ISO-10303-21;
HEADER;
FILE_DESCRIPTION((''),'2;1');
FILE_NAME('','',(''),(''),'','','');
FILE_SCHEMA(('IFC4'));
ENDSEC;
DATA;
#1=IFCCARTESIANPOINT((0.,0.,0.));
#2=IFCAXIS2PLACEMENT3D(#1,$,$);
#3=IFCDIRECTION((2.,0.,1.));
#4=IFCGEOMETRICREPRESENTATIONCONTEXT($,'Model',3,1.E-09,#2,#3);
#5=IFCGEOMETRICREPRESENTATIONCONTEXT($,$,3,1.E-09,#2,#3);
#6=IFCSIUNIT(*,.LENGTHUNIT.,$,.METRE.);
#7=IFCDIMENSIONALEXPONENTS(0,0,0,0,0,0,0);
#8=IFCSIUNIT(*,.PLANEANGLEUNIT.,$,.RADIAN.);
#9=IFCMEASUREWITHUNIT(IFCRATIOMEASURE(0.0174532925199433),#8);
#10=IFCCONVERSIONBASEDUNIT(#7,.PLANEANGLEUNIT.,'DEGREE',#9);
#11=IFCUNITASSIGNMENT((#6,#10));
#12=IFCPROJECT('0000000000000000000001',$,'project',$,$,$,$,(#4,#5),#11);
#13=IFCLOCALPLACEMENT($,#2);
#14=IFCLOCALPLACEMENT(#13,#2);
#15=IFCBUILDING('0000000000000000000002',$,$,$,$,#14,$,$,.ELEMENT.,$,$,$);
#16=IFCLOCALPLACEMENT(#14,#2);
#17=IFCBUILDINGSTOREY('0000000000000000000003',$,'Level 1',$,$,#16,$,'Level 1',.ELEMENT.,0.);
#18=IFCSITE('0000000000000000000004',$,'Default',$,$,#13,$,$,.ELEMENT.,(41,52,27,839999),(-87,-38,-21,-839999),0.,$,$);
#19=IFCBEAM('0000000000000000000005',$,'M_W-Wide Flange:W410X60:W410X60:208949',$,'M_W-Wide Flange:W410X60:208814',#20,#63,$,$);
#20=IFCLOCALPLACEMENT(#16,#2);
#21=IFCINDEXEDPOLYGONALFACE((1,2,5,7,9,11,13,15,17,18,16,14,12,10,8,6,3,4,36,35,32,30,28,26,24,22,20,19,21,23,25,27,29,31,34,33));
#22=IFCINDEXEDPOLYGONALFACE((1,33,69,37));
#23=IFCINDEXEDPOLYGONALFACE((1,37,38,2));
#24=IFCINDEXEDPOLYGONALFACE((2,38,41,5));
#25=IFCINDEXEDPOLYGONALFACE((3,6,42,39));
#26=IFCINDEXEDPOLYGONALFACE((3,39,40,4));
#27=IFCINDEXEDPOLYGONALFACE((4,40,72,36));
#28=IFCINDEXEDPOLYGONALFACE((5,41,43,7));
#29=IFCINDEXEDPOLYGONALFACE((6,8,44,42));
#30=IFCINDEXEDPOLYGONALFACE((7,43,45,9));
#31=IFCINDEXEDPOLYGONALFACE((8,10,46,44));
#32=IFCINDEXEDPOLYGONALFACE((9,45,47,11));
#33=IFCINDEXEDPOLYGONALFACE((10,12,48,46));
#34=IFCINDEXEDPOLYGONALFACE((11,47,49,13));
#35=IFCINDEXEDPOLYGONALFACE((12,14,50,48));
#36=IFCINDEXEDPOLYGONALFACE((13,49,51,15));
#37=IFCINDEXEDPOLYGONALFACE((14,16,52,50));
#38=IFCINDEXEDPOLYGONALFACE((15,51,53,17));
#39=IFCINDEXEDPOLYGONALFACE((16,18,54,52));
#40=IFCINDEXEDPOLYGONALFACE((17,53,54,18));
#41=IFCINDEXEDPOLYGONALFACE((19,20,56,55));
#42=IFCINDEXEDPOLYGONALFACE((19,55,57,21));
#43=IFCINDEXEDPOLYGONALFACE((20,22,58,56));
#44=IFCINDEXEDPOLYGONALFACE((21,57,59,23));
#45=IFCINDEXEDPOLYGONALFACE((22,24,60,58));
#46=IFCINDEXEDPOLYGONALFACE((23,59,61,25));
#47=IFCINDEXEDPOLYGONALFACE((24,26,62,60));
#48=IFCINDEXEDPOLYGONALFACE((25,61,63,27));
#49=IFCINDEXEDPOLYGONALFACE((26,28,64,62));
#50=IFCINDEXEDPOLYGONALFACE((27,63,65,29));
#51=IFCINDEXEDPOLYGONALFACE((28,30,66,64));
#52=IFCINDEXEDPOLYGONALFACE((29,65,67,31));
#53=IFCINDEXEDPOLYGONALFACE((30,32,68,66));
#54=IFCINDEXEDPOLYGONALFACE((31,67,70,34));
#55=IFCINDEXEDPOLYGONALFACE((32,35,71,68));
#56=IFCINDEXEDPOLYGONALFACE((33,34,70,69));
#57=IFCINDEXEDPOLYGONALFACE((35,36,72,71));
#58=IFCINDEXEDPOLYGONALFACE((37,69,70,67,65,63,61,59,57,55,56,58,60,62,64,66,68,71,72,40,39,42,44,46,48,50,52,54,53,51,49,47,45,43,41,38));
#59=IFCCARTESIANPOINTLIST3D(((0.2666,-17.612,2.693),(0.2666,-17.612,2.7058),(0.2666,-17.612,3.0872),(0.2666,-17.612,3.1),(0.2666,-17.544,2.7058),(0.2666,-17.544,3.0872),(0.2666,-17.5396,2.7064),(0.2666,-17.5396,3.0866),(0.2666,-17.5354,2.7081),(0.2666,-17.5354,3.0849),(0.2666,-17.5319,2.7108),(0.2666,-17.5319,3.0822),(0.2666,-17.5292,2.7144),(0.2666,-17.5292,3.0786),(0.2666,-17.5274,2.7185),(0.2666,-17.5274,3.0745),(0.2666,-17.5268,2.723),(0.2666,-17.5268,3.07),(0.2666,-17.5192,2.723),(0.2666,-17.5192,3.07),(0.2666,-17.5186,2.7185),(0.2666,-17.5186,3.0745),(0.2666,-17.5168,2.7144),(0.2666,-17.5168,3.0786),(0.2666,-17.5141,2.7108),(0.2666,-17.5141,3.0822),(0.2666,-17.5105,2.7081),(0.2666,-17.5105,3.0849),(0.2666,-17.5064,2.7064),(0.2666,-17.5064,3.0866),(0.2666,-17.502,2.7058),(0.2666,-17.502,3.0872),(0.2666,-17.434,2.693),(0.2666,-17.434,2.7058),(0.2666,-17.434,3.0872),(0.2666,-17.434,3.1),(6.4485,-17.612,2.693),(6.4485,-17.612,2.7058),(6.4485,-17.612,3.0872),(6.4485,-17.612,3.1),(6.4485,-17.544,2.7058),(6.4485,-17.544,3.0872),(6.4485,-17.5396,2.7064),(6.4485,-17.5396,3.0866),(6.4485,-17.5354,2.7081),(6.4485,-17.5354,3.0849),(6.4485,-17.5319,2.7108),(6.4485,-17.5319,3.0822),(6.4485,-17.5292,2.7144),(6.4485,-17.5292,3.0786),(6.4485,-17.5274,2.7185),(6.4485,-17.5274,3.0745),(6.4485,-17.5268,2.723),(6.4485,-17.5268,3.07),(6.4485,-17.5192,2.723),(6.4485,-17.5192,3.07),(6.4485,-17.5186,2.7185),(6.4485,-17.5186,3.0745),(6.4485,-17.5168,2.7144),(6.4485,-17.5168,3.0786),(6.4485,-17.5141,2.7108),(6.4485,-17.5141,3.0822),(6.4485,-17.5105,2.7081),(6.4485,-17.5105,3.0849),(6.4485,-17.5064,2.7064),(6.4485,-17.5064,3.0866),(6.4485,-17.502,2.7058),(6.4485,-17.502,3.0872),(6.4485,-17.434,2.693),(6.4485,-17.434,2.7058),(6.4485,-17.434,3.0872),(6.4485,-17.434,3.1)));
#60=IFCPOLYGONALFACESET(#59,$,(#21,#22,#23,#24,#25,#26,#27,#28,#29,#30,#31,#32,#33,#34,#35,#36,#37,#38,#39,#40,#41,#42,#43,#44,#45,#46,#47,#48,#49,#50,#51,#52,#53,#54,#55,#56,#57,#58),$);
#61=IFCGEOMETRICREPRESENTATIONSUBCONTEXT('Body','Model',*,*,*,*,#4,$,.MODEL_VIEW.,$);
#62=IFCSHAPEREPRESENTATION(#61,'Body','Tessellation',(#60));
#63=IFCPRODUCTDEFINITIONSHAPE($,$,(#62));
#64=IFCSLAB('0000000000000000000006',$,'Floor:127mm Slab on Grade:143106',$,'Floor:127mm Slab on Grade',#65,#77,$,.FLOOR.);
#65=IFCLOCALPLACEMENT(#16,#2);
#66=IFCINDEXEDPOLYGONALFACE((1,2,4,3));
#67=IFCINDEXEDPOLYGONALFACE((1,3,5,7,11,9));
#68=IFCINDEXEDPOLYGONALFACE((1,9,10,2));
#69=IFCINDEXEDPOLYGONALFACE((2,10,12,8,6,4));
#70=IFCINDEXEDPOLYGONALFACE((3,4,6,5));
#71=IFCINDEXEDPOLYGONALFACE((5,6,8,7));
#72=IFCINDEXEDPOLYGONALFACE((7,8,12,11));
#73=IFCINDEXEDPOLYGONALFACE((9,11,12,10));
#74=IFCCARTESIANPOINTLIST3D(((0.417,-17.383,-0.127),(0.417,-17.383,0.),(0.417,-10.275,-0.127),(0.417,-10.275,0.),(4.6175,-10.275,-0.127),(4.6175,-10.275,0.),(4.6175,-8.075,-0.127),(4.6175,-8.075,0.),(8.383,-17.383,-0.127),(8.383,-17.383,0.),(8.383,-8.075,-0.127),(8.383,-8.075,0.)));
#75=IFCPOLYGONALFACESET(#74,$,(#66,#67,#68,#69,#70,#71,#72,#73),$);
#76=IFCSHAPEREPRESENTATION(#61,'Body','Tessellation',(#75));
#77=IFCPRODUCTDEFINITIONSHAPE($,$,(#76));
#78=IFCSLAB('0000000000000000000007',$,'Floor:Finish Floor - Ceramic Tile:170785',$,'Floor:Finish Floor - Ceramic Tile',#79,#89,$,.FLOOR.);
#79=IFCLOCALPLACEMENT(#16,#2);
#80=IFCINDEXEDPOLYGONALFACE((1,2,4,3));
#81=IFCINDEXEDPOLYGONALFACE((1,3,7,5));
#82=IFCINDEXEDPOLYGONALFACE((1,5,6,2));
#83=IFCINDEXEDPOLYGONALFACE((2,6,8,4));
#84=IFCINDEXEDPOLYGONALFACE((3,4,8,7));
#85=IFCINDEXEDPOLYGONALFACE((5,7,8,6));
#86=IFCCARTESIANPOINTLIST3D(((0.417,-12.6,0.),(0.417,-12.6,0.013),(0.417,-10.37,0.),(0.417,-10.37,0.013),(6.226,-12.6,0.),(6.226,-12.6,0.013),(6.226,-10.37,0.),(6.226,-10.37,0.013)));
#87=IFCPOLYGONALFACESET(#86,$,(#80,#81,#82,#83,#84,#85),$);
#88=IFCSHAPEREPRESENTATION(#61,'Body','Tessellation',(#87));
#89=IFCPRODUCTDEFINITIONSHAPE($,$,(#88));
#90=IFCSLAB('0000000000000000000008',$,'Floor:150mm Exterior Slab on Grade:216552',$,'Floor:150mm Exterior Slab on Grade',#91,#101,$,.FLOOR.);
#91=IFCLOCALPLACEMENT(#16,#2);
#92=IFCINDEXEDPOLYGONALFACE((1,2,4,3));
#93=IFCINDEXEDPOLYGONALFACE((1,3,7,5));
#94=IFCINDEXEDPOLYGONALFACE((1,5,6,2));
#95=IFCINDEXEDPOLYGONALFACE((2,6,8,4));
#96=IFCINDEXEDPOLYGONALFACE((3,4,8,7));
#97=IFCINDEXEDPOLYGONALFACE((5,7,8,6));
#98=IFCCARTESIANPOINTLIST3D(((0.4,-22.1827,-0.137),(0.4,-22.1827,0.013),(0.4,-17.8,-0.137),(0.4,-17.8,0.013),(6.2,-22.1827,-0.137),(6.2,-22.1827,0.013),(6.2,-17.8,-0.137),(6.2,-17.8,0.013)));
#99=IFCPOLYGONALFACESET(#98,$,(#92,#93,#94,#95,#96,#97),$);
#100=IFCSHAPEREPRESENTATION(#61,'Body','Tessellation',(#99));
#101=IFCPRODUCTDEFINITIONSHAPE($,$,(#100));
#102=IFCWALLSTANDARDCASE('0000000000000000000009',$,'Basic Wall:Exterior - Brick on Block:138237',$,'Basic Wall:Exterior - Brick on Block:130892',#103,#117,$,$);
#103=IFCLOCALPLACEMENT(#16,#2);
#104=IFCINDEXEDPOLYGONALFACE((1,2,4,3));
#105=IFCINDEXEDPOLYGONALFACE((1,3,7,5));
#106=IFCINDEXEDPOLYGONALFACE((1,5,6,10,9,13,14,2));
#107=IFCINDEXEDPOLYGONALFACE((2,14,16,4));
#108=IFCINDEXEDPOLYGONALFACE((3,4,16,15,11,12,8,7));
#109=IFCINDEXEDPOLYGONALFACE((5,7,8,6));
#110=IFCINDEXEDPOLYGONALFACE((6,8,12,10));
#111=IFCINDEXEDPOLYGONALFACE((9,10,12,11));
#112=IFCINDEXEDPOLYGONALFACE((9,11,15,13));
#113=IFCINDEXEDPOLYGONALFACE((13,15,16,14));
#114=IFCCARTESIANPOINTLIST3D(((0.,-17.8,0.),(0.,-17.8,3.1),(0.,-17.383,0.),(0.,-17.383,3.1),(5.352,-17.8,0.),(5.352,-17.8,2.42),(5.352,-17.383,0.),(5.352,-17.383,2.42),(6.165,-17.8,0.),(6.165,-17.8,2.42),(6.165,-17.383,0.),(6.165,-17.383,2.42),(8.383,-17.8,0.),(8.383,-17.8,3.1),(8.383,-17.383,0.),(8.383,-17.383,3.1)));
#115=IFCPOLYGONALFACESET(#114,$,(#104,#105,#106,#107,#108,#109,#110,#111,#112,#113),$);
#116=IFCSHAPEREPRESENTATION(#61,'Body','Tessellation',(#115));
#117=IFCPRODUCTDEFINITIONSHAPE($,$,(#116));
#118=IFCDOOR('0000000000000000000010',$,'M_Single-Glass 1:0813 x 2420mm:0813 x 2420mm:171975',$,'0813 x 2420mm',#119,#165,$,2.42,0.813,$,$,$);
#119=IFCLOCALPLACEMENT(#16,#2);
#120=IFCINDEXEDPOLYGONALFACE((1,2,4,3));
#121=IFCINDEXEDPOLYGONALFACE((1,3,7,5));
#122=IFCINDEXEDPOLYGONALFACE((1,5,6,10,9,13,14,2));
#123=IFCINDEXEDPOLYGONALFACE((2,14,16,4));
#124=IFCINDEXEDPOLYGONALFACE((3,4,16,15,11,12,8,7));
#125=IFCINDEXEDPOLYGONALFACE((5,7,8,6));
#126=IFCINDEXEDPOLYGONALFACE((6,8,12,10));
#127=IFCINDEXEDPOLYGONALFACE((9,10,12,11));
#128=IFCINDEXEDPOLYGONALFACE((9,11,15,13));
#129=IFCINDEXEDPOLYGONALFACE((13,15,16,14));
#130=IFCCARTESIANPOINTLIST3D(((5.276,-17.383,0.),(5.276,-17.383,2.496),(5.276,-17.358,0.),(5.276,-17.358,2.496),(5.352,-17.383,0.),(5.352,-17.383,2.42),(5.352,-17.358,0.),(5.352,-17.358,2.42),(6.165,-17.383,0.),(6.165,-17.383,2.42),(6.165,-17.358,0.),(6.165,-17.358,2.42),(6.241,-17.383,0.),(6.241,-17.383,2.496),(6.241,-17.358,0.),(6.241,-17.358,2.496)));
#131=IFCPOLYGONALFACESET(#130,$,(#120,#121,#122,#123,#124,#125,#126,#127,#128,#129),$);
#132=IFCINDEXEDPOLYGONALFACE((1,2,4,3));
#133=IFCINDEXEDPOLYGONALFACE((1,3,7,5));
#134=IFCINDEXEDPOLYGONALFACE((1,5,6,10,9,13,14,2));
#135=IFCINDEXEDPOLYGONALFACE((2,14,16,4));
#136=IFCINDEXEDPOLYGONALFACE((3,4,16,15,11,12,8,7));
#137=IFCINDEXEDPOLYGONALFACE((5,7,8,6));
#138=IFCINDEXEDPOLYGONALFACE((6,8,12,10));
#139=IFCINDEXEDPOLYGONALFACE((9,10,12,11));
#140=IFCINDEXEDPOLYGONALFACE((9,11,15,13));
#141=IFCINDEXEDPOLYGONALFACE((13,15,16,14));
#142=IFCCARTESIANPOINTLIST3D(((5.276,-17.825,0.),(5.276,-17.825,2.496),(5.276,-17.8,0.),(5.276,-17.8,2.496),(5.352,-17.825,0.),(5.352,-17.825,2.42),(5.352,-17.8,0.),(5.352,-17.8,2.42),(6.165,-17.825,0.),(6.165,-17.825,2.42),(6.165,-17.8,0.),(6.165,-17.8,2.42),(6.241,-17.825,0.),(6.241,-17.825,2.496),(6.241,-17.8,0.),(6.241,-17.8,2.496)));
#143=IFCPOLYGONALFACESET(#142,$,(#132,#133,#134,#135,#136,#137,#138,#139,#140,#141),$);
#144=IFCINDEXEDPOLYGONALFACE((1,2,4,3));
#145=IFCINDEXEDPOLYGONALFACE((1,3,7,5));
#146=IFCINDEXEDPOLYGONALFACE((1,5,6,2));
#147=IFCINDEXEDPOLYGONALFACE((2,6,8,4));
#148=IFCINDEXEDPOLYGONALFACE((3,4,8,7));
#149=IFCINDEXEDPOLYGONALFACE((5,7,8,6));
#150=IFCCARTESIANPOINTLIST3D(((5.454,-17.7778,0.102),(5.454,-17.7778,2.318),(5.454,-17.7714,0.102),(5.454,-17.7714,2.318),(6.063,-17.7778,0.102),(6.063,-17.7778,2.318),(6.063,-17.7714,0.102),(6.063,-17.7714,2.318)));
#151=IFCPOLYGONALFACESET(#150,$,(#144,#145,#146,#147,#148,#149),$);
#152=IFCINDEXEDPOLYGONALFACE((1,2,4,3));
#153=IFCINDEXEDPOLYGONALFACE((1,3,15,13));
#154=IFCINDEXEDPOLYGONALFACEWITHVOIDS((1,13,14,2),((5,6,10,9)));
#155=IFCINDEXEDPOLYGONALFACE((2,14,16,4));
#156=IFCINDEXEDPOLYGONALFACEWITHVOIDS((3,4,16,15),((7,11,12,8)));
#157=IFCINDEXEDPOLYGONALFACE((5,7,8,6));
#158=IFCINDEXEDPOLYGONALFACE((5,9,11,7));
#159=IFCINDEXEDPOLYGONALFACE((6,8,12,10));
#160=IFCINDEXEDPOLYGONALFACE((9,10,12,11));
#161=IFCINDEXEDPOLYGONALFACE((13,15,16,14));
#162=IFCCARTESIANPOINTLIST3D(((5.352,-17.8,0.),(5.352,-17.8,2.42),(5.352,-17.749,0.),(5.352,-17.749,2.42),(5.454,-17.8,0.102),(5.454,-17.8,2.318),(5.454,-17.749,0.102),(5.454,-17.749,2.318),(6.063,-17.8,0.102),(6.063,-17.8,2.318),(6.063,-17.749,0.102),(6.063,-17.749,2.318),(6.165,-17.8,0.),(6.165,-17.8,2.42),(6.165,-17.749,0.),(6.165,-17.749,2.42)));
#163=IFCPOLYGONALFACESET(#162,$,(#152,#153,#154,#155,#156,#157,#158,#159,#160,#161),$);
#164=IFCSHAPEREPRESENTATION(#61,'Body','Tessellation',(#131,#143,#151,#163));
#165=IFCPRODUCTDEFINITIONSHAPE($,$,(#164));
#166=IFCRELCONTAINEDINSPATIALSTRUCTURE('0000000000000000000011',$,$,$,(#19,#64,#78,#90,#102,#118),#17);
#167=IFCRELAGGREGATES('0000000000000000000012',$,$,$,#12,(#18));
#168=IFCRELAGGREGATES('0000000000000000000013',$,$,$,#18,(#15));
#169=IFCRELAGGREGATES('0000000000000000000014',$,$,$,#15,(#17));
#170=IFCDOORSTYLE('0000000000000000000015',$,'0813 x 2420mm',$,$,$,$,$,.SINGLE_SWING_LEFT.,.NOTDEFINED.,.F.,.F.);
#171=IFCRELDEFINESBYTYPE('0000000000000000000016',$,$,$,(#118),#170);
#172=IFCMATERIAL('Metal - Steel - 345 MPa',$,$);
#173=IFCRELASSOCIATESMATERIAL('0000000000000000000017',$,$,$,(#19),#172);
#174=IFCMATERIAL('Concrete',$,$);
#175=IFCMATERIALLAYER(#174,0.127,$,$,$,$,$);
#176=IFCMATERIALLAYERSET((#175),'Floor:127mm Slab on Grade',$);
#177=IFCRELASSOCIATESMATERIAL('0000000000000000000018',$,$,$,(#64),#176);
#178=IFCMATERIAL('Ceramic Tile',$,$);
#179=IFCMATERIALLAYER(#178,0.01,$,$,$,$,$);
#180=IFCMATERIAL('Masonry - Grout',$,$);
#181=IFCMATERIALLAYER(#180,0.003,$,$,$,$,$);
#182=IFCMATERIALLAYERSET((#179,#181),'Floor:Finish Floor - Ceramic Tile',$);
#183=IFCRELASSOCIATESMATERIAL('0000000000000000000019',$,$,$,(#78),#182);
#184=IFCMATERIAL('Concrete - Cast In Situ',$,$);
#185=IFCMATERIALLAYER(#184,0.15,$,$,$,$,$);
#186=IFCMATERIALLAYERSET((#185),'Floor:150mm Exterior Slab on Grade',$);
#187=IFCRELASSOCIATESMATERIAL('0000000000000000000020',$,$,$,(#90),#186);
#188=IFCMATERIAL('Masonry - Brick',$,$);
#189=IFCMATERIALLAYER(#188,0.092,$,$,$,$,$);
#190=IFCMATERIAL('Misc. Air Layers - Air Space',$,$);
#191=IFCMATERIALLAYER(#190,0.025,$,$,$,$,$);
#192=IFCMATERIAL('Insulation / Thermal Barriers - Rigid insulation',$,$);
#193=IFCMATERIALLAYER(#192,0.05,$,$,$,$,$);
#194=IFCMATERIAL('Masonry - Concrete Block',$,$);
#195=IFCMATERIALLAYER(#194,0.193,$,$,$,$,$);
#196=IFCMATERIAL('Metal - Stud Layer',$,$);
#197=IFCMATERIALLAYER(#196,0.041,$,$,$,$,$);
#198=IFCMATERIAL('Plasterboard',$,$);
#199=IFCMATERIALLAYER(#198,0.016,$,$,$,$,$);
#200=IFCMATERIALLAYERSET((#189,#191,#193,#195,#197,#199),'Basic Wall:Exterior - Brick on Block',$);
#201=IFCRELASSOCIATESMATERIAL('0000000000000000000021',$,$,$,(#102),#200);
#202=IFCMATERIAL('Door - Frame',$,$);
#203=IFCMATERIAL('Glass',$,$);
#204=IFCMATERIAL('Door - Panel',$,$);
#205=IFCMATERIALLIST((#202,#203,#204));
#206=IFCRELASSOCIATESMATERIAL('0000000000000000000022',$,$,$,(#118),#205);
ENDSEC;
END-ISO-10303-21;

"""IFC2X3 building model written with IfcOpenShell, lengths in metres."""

from ifc_helpers import new_model, entity, si_unit, converted_unit, direction, frame, frame_2d, origin, origin_2d_with_axis, place, context, subcontext, project, spatial, polyline, rectangle, i_section, outline, extrude, source, transform, mapped, material, material_list, layer, layer_set, layer_usage, type_object, type_shapes, element, fill, save


model = new_model("IFC2X3")

# Units and contexts
model_context = context("Model", 3, precision=1e-09, world=origin(), true_north=direction((2.0, 0.0, 1.0)))
context_of_model = context(None, 3, precision=1e-09, world=origin(), true_north=direction((2.0, 0.0, 1.0)))
body_context = subcontext(model_context, "Body", "Model", "MODEL_VIEW")
ifc_project = project(units=[si_unit("LENGTHUNIT", "METRE"), converted_unit("PLANEANGLEUNIT", "DEGREE", entity("IfcRatioMeasure", 0.0174532925199433), si_unit("PLANEANGLEUNIT", "RADIAN"), dimensions=[0, 0, 0, 0, 0, 0, 0])], contexts=[model_context, context_of_model])

# Site, building, storey
site_placement = place(None, origin())
site = spatial("IfcSite", under=ifc_project, at=site_placement, Name="Default", CompositionType="ELEMENT", RefLatitude=(41, 52, 27, 839999), RefLongitude=(-87, -38, -21, -839999), RefElevation=0.0)
building_placement = place(site_placement, origin())
building = spatial("IfcBuilding", under=site, at=building_placement, CompositionType="ELEMENT")
storey_placement = place(building_placement, origin())
storey = spatial("IfcBuildingStorey", under=building, at=storey_placement, Name="Level 1", LongName="Level 1", CompositionType="ELEMENT", Elevation=0.0)

# Beam
ifc_material_1 = material(Name="Metal - Steel - 345 MPa")
beam_placement = place(storey_placement, frame((0.2085, -17.523, 3.1)))
element("IfcBeam", 1, at=beam_placement, inside=storey, material=ifc_material_1, Name="M_W-Wide Flange:W410X60:W410X60:208949", ObjectType="M_W-Wide Flange:W410X60:208814", context=body_context, shape_type="SweptSolid", body=[
    extrude(i_section(OverallWidth=0.178, OverallDepth=0.407, WebThickness=0.0077, FlangeThickness=0.0128, FilletRadius=0.0172, at=frame_2d((0.0, 0.0), x_axis=(1.0, 0.0))), frame((0.0581, 0.0, -0.2035), z_axis=(-1.0, 0.0, 0.0), x_axis=(0.0, -1.0, 0.0)), (0.0, 0.0, -1.0), 6.1819),
])

# Slabs
ifc_material_2 = material(Name="Concrete")
ifc_layer_1 = layer(ifc_material_2, 0.127)
ifc_layer_set_1 = layer_set([ifc_layer_1], Name="Floor:127mm Slab on Grade")
ifc_layer_usage_1 = layer_usage(ifc_layer_set_1, "AXIS3", "POSITIVE", 0.0)
slab_1_placement = place(storey_placement, frame((0.417, -17.383, -0.127)))
element("IfcSlab", 2, at=slab_1_placement, inside=storey, material=ifc_layer_usage_1, Name="Floor:127mm Slab on Grade:143106", ObjectType="Floor:127mm Slab on Grade", PredefinedType="FLOOR", context=body_context, shape_type="SweptSolid", body=[
    extrude(outline(polyline([(-3.983, 4.654), (-3.983, -4.654), (3.983, -4.654), (3.983, 2.454), (-0.2175, 2.454), (-0.2175, 4.654), (-3.983, 4.654)])), frame((3.983, 4.654, 0.127), z_axis=(0.0, 0.0, -1.0), x_axis=(-1.0, 0.0, 0.0)), (0.0, 0.0, 1.0), 0.127),
])
ifc_material_3 = material(Name="Ceramic Tile")
ifc_layer_2 = layer(ifc_material_3, 0.01)
ifc_material_4 = material(Name="Masonry - Grout")
ifc_layer_3 = layer(ifc_material_4, 0.003)
ifc_layer_set_2 = layer_set([ifc_layer_2, ifc_layer_3], Name="Floor:Finish Floor - Ceramic Tile")
ifc_layer_usage_2 = layer_usage(ifc_layer_set_2, "AXIS3", "POSITIVE", 0.0)
slab_2_placement = place(storey_placement, frame((0.417, -12.6, 0.0)))
element("IfcSlab", 3, at=slab_2_placement, inside=storey, material=ifc_layer_usage_2, Name="Floor:Finish Floor - Ceramic Tile:170785", ObjectType="Floor:Finish Floor - Ceramic Tile", PredefinedType="FLOOR", context=body_context, shape_type="SweptSolid", body=[
    extrude(rectangle(XDim=5.809, YDim=2.23, at=frame_2d((0.0, 0.0), x_axis=(-1.0, 0.0))), frame((2.9045, 1.115, 0.013), z_axis=(0.0, 0.0, -1.0), x_axis=(-1.0, 0.0, 0.0)), (0.0, 0.0, 1.0), 0.013),
])
ifc_material_5 = material(Name="Concrete - Cast In Situ")
ifc_layer_4 = layer(ifc_material_5, 0.15)
ifc_layer_set_3 = layer_set([ifc_layer_4], Name="Floor:150mm Exterior Slab on Grade")
ifc_layer_usage_3 = layer_usage(ifc_layer_set_3, "AXIS3", "POSITIVE", 0.0)
slab_3_placement = place(storey_placement, frame((0.4, -22.1827, -0.137)))
element("IfcSlab", 4, at=slab_3_placement, inside=storey, material=ifc_layer_usage_3, Name="Floor:150mm Exterior Slab on Grade:216552", ObjectType="Floor:150mm Exterior Slab on Grade", PredefinedType="FLOOR", context=body_context, shape_type="SweptSolid", body=[
    extrude(rectangle(XDim=5.8, YDim=4.3827, at=origin_2d_with_axis()), frame((2.9, 2.1914, 0.15), z_axis=(0.0, 0.0, -1.0), x_axis=(-1.0, 0.0, 0.0)), (0.0, 0.0, 1.0), 0.15),
])

# Wall, opening, door
ifc_material_6 = material(Name="Masonry - Brick")
ifc_layer_5 = layer(ifc_material_6, 0.092)
ifc_material_7 = material(Name="Misc. Air Layers - Air Space")
ifc_layer_6 = layer(ifc_material_7, 0.025)
ifc_material_8 = material(Name="Insulation / Thermal Barriers - Rigid insulation")
ifc_layer_7 = layer(ifc_material_8, 0.05)
ifc_material_9 = material(Name="Masonry - Concrete Block")
ifc_layer_8 = layer(ifc_material_9, 0.193)
ifc_material_10 = material(Name="Metal - Stud Layer")
ifc_layer_9 = layer(ifc_material_10, 0.041)
ifc_material_11 = material(Name="Plasterboard")
ifc_layer_10 = layer(ifc_material_11, 0.016)
ifc_layer_set_4 = layer_set([ifc_layer_5, ifc_layer_6, ifc_layer_7, ifc_layer_8, ifc_layer_9, ifc_layer_10], Name="Basic Wall:Exterior - Brick on Block")
ifc_layer_usage_4 = layer_usage(ifc_layer_set_4, "AXIS2", "NEGATIVE", 0.2085)
wall_1_placement = place(storey_placement, frame((8.383, -17.5915, 0.0), z_axis=(0.0, 0.0, 1.0), x_axis=(-1.0, 0.0, 0.0)))
wall_1 = element("IfcWallStandardCase", 5, at=wall_1_placement, inside=storey, material=ifc_layer_usage_4, Name="Basic Wall:Exterior - Brick on Block:138237", ObjectType="Basic Wall:Exterior - Brick on Block:130892", context=body_context, shape_type="SweptSolid", body=[
    extrude(rectangle(XDim=8.383, YDim=0.417, at=frame_2d((4.1915, 0.0), x_axis=(-1.0, 0.0))), origin(), (0.0, 0.0, 1.0), 3.1),
])
opening_1_placement = place(wall_1_placement, frame((2.218, -0.2085, 0.0)))
opening_1 = element("IfcOpeningElement", 6, at=opening_1_placement, cuts=wall_1, ObjectType="Opening", context=body_context, shape_type="SweptSolid", body=[
    extrude(rectangle(XDim=0.813, YDim=2.42, at=frame_2d((1.21, 0.4065), x_axis=(0.0, -1.0))), frame((0.0, 0.0, 0.0), z_axis=(0.0, 1.0, 0.0), x_axis=(0.0, 0.0, 1.0)), (0.0, 0.0, 1.0), 0.417),
])
ifc_material_12 = material(Name="Door - Frame")
ifc_material_13 = material(Name="Glass")
ifc_material_14 = material(Name="Door - Panel")
ifc_material_list_1 = material_list([ifc_material_12, ifc_material_13, ifc_material_14])
door_style_1 = type_object("IfcDoorStyle", Name="0813 x 2420mm", ConstructionType="NOTDEFINED", OperationType="SINGLE_SWING_LEFT", ParameterTakesPrecedence=False, Sizeable=False)
shared_shape_1 = source(origin(), body_context, "Body", "SweptSolid", [
    extrude(outline(polyline([(-0.4065, -1.191), (-0.4065, 1.229), (-0.4825, 1.229), (-0.4825, -1.267), (0.4825, -1.267), (0.4825, 1.229), (0.4065, 1.229), (0.4065, -1.191), (-0.4065, -1.191)])), frame((0.4065, 0.0, 1.229), z_axis=(0.0, 1.0, 0.0), x_axis=(1.0, 0.0, 0.0)), (0.0, 0.0, -1.0), 0.025),
    extrude(outline(polyline([(-0.4065, -1.191), (-0.4065, 1.229), (-0.4825, 1.229), (-0.4825, -1.267), (0.4825, -1.267), (0.4825, 1.229), (0.4065, 1.229), (0.4065, -1.191), (-0.4065, -1.191)])), frame((0.4065, 0.442, 1.229), z_axis=(0.0, 1.0, 0.0), x_axis=(1.0, 0.0, 0.0)), (0.0, 0.0, -1.0), 0.025),
    extrude(rectangle(XDim=0.609, YDim=0.0064, at=frame_2d((0.0, 0.0), x_axis=(1.0, 0.0))), frame((0.4065, 0.3916, 0.102)), (0.0, 0.0, 1.0), 2.216),
    extrude(outline(polyline([(-1.21, -0.4065), (1.21, -0.4065), (1.21, 0.4065), (-1.21, 0.4065), (-1.21, -0.4065)]), holes=[polyline([(-1.108, 0.3045), (1.108, 0.3045), (1.108, -0.3045), (-1.108, -0.3045), (-1.108, 0.3045)])]), frame((0.4065, 0.417, 1.21), z_axis=(0.0, -1.0, 0.0), x_axis=(0.0, 0.0, -1.0)), (0.0, 0.0, 1.0), 0.051),
])
type_shapes(door_style_1, [shared_shape_1])
door_1_placement = place(opening_1_placement, origin())
door_1 = element("IfcDoor", 7, at=door_1_placement, inside=storey, type_object=door_style_1, material=ifc_material_list_1, Name="M_Single-Glass 1:0813 x 2420mm:0813 x 2420mm:171975", ObjectType="0813 x 2420mm", OverallHeight=2.42, OverallWidth=0.813, context=body_context, shape_type="MappedRepresentation", body=[
    mapped(shared_shape_1, transform((0.0, 0.0, 0.0), scale=1.0)),
])
fill(opening_1, door_1)

save(model, "model.ifc")
